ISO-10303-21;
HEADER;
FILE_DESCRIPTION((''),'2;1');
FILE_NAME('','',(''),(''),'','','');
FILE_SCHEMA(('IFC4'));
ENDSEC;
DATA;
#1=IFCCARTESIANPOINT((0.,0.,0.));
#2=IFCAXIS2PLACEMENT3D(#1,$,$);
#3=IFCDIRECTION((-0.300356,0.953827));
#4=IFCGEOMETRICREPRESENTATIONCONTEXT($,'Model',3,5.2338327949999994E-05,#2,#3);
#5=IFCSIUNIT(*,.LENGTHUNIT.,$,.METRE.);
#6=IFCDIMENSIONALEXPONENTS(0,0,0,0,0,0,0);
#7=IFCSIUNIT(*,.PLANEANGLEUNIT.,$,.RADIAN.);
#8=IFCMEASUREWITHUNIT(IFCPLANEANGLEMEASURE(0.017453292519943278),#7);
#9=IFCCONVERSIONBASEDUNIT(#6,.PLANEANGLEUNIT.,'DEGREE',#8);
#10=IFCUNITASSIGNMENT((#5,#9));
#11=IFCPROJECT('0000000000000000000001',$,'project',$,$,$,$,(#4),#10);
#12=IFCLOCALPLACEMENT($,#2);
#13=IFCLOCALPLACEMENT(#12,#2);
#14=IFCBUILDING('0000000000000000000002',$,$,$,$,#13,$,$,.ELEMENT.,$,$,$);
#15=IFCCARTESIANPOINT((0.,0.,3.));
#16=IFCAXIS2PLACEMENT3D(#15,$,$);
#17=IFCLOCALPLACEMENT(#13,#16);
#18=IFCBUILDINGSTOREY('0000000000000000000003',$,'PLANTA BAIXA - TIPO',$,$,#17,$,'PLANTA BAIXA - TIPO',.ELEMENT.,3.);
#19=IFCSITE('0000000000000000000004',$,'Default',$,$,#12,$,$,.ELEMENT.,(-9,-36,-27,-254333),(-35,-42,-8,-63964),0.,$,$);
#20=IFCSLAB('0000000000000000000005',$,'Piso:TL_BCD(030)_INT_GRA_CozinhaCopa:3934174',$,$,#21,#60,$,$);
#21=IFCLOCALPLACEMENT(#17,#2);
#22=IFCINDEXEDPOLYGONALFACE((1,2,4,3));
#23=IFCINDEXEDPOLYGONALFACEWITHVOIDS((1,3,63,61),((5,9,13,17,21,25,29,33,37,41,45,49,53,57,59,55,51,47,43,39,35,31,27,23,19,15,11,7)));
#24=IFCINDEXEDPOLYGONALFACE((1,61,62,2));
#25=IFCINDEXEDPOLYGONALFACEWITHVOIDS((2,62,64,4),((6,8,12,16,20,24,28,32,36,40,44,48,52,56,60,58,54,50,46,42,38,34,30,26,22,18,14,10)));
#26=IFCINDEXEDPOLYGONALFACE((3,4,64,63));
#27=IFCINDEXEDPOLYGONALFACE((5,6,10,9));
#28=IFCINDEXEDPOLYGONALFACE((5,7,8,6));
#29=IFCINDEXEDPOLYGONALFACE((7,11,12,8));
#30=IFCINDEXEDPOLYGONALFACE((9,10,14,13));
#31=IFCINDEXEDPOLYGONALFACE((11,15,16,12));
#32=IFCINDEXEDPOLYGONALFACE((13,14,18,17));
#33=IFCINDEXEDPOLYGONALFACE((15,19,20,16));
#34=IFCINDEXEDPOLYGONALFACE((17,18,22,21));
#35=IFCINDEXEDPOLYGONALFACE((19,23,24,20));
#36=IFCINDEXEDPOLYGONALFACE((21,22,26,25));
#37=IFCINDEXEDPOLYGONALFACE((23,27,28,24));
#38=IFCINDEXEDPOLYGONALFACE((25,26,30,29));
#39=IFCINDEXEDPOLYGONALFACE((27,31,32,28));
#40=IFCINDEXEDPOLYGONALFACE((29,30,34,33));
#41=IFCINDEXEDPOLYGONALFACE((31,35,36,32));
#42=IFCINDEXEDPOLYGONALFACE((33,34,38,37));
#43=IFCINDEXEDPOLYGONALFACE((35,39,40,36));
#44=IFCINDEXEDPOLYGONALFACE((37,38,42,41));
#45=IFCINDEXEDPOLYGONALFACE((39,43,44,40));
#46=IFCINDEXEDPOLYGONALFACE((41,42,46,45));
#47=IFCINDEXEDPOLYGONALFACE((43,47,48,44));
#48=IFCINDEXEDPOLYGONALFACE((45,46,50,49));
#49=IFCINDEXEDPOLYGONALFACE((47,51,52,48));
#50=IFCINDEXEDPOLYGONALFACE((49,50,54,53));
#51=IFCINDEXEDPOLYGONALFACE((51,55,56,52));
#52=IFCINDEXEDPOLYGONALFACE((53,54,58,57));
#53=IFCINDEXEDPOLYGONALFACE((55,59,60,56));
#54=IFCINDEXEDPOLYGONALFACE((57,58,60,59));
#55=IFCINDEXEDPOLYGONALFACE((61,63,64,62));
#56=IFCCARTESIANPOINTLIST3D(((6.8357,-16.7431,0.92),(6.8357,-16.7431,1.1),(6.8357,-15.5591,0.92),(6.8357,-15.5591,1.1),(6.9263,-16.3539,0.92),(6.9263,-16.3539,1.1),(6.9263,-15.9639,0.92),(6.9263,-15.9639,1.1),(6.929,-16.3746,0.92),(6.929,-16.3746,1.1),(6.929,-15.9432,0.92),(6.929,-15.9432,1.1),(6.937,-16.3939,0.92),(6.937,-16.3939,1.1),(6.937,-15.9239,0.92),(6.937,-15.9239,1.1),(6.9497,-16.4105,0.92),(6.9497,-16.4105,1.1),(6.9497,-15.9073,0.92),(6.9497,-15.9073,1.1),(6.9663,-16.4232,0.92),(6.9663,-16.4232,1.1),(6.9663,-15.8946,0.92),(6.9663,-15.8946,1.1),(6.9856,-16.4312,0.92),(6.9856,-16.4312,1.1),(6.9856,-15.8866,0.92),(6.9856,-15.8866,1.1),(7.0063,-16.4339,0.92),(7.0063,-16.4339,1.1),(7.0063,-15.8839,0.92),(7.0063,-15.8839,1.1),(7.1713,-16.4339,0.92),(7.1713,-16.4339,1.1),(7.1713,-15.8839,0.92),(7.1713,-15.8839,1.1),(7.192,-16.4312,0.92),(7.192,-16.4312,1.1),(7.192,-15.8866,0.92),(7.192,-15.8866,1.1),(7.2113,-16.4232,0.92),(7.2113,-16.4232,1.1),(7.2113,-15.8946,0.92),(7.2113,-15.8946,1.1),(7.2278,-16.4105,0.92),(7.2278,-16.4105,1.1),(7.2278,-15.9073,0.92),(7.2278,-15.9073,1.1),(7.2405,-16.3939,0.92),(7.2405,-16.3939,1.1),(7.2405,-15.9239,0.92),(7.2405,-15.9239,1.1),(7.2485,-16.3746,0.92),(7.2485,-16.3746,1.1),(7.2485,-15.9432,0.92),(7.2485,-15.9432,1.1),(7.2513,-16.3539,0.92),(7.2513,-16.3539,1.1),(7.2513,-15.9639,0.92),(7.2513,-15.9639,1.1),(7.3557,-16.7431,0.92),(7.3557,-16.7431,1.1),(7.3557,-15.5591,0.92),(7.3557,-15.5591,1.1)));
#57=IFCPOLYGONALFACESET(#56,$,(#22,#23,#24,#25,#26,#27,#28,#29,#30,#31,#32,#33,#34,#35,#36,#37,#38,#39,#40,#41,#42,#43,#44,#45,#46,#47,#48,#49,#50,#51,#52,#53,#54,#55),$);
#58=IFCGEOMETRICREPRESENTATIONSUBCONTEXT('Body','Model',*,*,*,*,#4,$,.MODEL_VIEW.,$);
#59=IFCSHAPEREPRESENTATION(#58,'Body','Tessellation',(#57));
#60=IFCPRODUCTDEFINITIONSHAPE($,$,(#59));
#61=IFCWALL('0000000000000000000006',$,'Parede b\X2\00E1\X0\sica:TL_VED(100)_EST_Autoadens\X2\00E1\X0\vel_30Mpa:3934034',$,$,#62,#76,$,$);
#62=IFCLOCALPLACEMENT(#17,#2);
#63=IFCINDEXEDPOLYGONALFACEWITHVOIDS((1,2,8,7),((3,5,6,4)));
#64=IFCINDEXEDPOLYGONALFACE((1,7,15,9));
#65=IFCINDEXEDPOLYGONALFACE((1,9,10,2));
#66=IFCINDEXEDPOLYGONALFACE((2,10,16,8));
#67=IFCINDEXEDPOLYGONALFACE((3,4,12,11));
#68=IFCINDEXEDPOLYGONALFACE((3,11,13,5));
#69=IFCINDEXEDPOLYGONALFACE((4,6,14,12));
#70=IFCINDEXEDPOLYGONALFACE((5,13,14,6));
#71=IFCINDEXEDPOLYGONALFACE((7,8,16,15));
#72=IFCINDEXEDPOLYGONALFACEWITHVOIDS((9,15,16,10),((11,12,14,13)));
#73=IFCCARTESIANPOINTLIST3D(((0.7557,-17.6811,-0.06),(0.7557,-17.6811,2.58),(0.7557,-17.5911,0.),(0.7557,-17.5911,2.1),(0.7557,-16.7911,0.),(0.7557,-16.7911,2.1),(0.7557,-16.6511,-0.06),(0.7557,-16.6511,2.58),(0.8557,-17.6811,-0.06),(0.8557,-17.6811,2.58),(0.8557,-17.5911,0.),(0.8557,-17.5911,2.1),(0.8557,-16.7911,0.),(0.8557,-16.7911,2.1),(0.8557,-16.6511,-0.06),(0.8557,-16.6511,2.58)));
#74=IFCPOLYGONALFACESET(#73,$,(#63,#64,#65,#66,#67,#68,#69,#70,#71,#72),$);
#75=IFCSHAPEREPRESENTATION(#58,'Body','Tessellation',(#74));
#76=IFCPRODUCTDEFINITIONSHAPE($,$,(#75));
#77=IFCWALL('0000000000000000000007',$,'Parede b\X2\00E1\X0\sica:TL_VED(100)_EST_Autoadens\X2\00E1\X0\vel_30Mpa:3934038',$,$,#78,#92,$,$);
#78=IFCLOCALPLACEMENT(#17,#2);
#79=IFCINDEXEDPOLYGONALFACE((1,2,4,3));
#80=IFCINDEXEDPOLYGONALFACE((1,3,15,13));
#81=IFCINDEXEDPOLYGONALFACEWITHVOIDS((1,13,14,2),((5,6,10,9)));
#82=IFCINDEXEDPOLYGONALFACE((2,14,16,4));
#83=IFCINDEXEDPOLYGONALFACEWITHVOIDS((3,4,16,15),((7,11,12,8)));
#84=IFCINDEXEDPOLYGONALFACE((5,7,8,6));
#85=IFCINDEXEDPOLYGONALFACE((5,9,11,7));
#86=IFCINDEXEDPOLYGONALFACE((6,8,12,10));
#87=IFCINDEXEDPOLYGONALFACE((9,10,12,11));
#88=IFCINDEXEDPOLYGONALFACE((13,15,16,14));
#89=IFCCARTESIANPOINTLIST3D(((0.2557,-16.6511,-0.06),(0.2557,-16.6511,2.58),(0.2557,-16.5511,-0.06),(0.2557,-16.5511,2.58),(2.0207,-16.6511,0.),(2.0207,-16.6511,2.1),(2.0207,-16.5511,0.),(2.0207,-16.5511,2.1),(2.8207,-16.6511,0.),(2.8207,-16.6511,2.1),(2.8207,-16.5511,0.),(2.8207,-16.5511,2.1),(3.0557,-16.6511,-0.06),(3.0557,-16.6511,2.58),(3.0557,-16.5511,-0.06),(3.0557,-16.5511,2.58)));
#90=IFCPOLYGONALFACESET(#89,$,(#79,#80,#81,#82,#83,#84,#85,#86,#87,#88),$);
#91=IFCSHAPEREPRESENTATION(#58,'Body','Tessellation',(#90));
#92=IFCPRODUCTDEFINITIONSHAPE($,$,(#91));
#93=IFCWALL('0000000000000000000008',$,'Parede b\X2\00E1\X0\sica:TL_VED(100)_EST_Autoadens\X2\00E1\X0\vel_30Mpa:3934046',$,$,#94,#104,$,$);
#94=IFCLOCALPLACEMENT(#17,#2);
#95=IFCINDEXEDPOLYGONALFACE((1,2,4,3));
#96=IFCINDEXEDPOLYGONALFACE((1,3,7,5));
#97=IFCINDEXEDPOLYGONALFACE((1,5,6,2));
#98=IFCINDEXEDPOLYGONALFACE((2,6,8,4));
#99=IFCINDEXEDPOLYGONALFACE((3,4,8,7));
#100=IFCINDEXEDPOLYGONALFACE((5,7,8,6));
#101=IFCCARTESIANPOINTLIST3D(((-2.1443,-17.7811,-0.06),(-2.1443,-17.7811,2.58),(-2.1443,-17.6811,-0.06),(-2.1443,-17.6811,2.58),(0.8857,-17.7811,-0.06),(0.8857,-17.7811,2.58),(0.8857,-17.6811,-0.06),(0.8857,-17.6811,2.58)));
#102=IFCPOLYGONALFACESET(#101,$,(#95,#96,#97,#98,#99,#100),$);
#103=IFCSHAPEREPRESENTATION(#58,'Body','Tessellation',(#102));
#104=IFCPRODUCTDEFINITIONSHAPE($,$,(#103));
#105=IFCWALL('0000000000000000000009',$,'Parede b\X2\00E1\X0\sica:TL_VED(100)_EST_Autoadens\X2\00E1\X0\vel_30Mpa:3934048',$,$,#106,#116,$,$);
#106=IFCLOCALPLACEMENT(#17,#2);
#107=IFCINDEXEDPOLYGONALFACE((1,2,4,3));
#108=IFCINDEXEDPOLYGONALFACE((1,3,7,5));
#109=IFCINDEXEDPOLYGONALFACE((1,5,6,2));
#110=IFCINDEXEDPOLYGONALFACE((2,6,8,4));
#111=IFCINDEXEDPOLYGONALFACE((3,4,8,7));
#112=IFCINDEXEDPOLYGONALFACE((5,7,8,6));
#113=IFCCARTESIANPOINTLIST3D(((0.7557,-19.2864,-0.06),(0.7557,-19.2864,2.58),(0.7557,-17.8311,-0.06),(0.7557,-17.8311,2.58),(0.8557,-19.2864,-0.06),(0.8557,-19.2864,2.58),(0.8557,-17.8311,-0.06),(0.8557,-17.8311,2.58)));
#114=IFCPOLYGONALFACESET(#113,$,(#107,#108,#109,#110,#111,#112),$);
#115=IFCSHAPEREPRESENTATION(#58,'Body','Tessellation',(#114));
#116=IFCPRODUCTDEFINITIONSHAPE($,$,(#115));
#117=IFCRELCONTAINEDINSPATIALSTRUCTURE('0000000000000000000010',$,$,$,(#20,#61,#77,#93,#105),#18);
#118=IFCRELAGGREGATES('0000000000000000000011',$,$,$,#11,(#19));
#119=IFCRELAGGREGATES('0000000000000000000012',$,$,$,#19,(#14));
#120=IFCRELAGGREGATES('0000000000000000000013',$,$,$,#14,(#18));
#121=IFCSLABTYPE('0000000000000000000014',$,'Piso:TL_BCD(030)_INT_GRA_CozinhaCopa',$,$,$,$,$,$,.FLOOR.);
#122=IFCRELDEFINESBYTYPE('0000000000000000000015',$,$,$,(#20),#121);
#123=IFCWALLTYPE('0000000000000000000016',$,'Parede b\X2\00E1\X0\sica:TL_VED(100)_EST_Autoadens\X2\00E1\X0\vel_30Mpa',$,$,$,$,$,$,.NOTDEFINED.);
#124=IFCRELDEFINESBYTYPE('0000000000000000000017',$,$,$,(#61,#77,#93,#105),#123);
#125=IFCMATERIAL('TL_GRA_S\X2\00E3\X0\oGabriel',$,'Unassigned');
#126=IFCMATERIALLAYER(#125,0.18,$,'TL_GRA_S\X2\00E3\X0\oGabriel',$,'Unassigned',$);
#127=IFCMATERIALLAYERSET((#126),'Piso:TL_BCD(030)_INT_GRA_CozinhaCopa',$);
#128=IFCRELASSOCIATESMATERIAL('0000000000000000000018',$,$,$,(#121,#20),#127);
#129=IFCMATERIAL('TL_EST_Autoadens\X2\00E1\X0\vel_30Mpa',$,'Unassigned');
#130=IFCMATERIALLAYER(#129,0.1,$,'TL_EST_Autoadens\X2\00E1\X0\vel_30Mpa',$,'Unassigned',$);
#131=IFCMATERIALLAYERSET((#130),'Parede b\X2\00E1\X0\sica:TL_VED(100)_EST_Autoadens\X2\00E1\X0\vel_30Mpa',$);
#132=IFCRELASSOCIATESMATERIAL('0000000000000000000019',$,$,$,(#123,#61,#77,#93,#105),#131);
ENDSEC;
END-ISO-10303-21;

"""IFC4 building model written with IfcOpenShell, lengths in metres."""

from ifc_helpers import new_model, entity, si_unit, converted_unit, direction, frame, frame_2d, origin, place, context, subcontext, project, spatial, polyline, circle_curve, parameter, trimmed, segment, composite_curve, rectangle, outline, extrude, material, layer, layer_set, layer_usage, type_object, element, save


model = new_model("IFC4")

# Units and contexts
model_context = context("Model", 3, precision=5.2338327949999994e-05, world=origin(), true_north=direction((-0.300356, 0.953827)))
body_context = subcontext(model_context, "Body", "Model", "MODEL_VIEW")
ifc_project = project(units=[si_unit("LENGTHUNIT", "METRE"), converted_unit("PLANEANGLEUNIT", "DEGREE", entity("IfcPlaneAngleMeasure", 0.017453292519943278), si_unit("PLANEANGLEUNIT", "RADIAN"), dimensions=[0, 0, 0, 0, 0, 0, 0])], contexts=[model_context])

# Site, building, storey
site_placement = place(None, origin())
site = spatial("IfcSite", under=ifc_project, at=site_placement, Name="Default", CompositionType="ELEMENT", RefLatitude=(-9, -36, -27, -254333), RefLongitude=(-35, -42, -8, -63964), RefElevation=0.0)
building_placement = place(site_placement, origin())
building = spatial("IfcBuilding", under=site, at=building_placement, CompositionType="ELEMENT")
storey_placement = place(building_placement, frame((0.0, 0.0, 3.0)))
storey = spatial("IfcBuildingStorey", under=building, at=storey_placement, Name="PLANTA BAIXA - TIPO", LongName="PLANTA BAIXA - TIPO", CompositionType="ELEMENT", Elevation=3.0)

# Slab, opening
ifc_material_1 = material(Name="TL_GRA_SãoGabriel", Category="Unassigned")
ifc_layer_1 = layer(ifc_material_1, 0.18, Name="TL_GRA_SãoGabriel", Category="Unassigned")
ifc_layer_set_1 = layer_set([ifc_layer_1], Name="Piso:TL_BCD(030)_INT_GRA_CozinhaCopa")
ifc_layer_usage_1 = layer_usage(ifc_layer_set_1, "AXIS3", "POSITIVE", 0.0)
slab_type = type_object("IfcSlabType", Name="Piso:TL_BCD(030)_INT_GRA_CozinhaCopa", PredefinedType="FLOOR", material=ifc_layer_set_1)
slab_placement = place(storey_placement, frame((6.8357, -16.7431, 0.92)))
slab = element("IfcSlab", 1, at=slab_placement, inside=storey, type_object=slab_type, material=ifc_layer_usage_1, Name="Piso:TL_BCD(030)_INT_GRA_CozinhaCopa:3934174", context=body_context, shape_type="SweptSolid", body=[
    extrude(rectangle(XDim=1.184, YDim=0.52, at=frame_2d((0.0, 0.0), x_axis=(0.0, -1.0))), frame((0.26, 0.592, 0.18), z_axis=(0.0, 0.0, -1.0), x_axis=(-1.0, 0.0, 0.0)), (0.0, 0.0, 1.0), 0.18),
])
opening_1_placement = place(slab_placement, frame((-6.8357, 16.7431, 0.18)))
element("IfcOpeningElement", 2, at=opening_1_placement, cuts=slab, PredefinedType="OPENING", context=body_context, shape_type="SweptSolid", body=[
    extrude(outline(composite_curve([segment(polyline([(-0.195, -0.1625), (0.195, -0.1625)]), True, "CONTINUOUS"), segment(trimmed(circle_curve(frame_2d((0.195, -0.0825), x_axis=(-1.0, 0.0)), 0.08), [parameter(90.0)], [parameter(180.0)], True, "PARAMETER"), True, "CONTINUOUS"), segment(polyline([(0.275, -0.0825), (0.275, 0.0825)]), True, "CONTINUOUS"), segment(trimmed(circle_curve(frame_2d((0.195, 0.0825), x_axis=(-1.0, 0.0)), 0.08), [parameter(180.0)], [parameter(270.0)], True, "PARAMETER"), True, "CONTINUOUS"), segment(polyline([(0.195, 0.1625), (-0.195, 0.1625)]), True, "CONTINUOUS"), segment(trimmed(circle_curve(frame_2d((-0.195, 0.0825), x_axis=(-1.0, 0.0)), 0.08), [parameter(270.0)], [parameter(360.0)], True, "PARAMETER"), True, "CONTINUOUS"), segment(polyline([(-0.275, 0.0825), (-0.275, -0.0825)]), True, "CONTINUOUS"), segment(trimmed(circle_curve(frame_2d((-0.195, -0.0825), x_axis=(-1.0, 0.0)), 0.08), [parameter(360.0)], [parameter(90.0)], True, "PARAMETER"), True, "CONTINUOUS")], self_intersect=False)), frame((7.0888, -16.1589, -0.21), z_axis=(0.0, 0.0, 1.0), x_axis=(0.0, 1.0, 0.0)), (0.0, 0.0, 1.0), 0.21),
])

# Walls, openings
ifc_material_2 = material(Name="TL_EST_Autoadensável_30Mpa", Category="Unassigned")
ifc_layer_2 = layer(ifc_material_2, 0.1, Name="TL_EST_Autoadensável_30Mpa", Category="Unassigned")
ifc_layer_set_2 = layer_set([ifc_layer_2], Name="Parede básica:TL_VED(100)_EST_Autoadensável_30Mpa")
ifc_layer_usage_2 = layer_usage(ifc_layer_set_2, "AXIS2", "POSITIVE", -0.05)
wall_type_1 = type_object("IfcWallType", Name="Parede básica:TL_VED(100)_EST_Autoadensável_30Mpa", PredefinedType="NOTDEFINED", material=ifc_layer_set_2)
wall_1_placement = place(storey_placement, frame((0.8057, -16.6511, -0.06), z_axis=(0.0, 0.0, 1.0), x_axis=(0.0, -1.0, 0.0)))
wall_1 = element("IfcWall", 3, at=wall_1_placement, inside=storey, type_object=wall_type_1, material=ifc_layer_usage_2, Name="Parede básica:TL_VED(100)_EST_Autoadensável_30Mpa:3934034", context=body_context, shape_type="SweptSolid", body=[
    extrude(rectangle(XDim=1.03, YDim=0.1, at=frame_2d((0.515, 0.0), x_axis=(-1.0, 0.0))), origin(), (0.0, 0.0, 1.0), 2.64),
])
opening_2_placement = place(wall_1_placement, frame((0.94, 0.05, 0.06)))
element("IfcOpeningElement", 4, at=opening_2_placement, cuts=wall_1, PredefinedType="OPENING", context=body_context, shape_type="SweptSolid", body=[
    extrude(rectangle(XDim=2.1, YDim=0.8, at=frame_2d((1.05, 0.4), x_axis=(1.0, 0.0))), frame((0.0, 0.0, 0.0), z_axis=(0.0, -1.0, 0.0), x_axis=(0.0, 0.0, 1.0)), (0.0, 0.0, 1.0), 0.1),
])
ifc_layer_usage_3 = layer_usage(ifc_layer_set_2, "AXIS2", "POSITIVE", -0.05)
wall_2_placement = place(storey_placement, frame((3.0557, -16.6011, -0.06), z_axis=(0.0, 0.0, 1.0), x_axis=(-1.0, 0.0, 0.0)))
wall_2 = element("IfcWall", 5, at=wall_2_placement, inside=storey, type_object=wall_type_1, material=ifc_layer_usage_3, Name="Parede básica:TL_VED(100)_EST_Autoadensável_30Mpa:3934038", context=body_context, shape_type="SweptSolid", body=[
    extrude(rectangle(XDim=2.8, YDim=0.1, at=frame_2d((1.4, 0.0), x_axis=(-1.0, 0.0))), origin(), (0.0, 0.0, 1.0), 2.64),
])
opening_3_placement = place(wall_2_placement, frame((1.035, 0.05, 0.06)))
element("IfcOpeningElement", 6, at=opening_3_placement, cuts=wall_2, PredefinedType="OPENING", context=body_context, shape_type="SweptSolid", body=[
    extrude(rectangle(XDim=2.1, YDim=0.8, at=frame_2d((1.05, 0.4), x_axis=(1.0, 0.0))), frame((0.0, 0.0, 0.0), z_axis=(0.0, -1.0, 0.0), x_axis=(0.0, 0.0, 1.0)), (0.0, 0.0, 1.0), 0.1),
])

# Walls
ifc_layer_usage_4 = layer_usage(ifc_layer_set_2, "AXIS2", "NEGATIVE", 0.05)
wall_3_placement = place(storey_placement, frame((0.8857, -17.7311, -0.06), z_axis=(0.0, 0.0, 1.0), x_axis=(-1.0, 0.0, 0.0)))
element("IfcWall", 7, at=wall_3_placement, inside=storey, type_object=wall_type_1, material=ifc_layer_usage_4, Name="Parede básica:TL_VED(100)_EST_Autoadensável_30Mpa:3934046", context=body_context, shape_type="SweptSolid", body=[
    extrude(rectangle(XDim=3.03, YDim=0.1, at=frame_2d((1.515, 0.0), x_axis=(-1.0, 0.0))), origin(), (0.0, 0.0, 1.0), 2.64),
])
ifc_layer_usage_5 = layer_usage(ifc_layer_set_2, "AXIS2", "POSITIVE", -0.05)
wall_4_placement = place(storey_placement, frame((0.8057, -19.2864, -0.06), z_axis=(0.0, 0.0, 1.0), x_axis=(0.0, 1.0, 0.0)))
element("IfcWall", 8, at=wall_4_placement, inside=storey, type_object=wall_type_1, material=ifc_layer_usage_5, Name="Parede básica:TL_VED(100)_EST_Autoadensável_30Mpa:3934048", context=body_context, shape_type="SweptSolid", body=[
    extrude(rectangle(XDim=1.4552, YDim=0.1, at=frame_2d((0.7276, 0.0), x_axis=(-1.0, 0.0))), origin(), (0.0, 0.0, 1.0), 2.64),
])

save(model, "model.ifc")
